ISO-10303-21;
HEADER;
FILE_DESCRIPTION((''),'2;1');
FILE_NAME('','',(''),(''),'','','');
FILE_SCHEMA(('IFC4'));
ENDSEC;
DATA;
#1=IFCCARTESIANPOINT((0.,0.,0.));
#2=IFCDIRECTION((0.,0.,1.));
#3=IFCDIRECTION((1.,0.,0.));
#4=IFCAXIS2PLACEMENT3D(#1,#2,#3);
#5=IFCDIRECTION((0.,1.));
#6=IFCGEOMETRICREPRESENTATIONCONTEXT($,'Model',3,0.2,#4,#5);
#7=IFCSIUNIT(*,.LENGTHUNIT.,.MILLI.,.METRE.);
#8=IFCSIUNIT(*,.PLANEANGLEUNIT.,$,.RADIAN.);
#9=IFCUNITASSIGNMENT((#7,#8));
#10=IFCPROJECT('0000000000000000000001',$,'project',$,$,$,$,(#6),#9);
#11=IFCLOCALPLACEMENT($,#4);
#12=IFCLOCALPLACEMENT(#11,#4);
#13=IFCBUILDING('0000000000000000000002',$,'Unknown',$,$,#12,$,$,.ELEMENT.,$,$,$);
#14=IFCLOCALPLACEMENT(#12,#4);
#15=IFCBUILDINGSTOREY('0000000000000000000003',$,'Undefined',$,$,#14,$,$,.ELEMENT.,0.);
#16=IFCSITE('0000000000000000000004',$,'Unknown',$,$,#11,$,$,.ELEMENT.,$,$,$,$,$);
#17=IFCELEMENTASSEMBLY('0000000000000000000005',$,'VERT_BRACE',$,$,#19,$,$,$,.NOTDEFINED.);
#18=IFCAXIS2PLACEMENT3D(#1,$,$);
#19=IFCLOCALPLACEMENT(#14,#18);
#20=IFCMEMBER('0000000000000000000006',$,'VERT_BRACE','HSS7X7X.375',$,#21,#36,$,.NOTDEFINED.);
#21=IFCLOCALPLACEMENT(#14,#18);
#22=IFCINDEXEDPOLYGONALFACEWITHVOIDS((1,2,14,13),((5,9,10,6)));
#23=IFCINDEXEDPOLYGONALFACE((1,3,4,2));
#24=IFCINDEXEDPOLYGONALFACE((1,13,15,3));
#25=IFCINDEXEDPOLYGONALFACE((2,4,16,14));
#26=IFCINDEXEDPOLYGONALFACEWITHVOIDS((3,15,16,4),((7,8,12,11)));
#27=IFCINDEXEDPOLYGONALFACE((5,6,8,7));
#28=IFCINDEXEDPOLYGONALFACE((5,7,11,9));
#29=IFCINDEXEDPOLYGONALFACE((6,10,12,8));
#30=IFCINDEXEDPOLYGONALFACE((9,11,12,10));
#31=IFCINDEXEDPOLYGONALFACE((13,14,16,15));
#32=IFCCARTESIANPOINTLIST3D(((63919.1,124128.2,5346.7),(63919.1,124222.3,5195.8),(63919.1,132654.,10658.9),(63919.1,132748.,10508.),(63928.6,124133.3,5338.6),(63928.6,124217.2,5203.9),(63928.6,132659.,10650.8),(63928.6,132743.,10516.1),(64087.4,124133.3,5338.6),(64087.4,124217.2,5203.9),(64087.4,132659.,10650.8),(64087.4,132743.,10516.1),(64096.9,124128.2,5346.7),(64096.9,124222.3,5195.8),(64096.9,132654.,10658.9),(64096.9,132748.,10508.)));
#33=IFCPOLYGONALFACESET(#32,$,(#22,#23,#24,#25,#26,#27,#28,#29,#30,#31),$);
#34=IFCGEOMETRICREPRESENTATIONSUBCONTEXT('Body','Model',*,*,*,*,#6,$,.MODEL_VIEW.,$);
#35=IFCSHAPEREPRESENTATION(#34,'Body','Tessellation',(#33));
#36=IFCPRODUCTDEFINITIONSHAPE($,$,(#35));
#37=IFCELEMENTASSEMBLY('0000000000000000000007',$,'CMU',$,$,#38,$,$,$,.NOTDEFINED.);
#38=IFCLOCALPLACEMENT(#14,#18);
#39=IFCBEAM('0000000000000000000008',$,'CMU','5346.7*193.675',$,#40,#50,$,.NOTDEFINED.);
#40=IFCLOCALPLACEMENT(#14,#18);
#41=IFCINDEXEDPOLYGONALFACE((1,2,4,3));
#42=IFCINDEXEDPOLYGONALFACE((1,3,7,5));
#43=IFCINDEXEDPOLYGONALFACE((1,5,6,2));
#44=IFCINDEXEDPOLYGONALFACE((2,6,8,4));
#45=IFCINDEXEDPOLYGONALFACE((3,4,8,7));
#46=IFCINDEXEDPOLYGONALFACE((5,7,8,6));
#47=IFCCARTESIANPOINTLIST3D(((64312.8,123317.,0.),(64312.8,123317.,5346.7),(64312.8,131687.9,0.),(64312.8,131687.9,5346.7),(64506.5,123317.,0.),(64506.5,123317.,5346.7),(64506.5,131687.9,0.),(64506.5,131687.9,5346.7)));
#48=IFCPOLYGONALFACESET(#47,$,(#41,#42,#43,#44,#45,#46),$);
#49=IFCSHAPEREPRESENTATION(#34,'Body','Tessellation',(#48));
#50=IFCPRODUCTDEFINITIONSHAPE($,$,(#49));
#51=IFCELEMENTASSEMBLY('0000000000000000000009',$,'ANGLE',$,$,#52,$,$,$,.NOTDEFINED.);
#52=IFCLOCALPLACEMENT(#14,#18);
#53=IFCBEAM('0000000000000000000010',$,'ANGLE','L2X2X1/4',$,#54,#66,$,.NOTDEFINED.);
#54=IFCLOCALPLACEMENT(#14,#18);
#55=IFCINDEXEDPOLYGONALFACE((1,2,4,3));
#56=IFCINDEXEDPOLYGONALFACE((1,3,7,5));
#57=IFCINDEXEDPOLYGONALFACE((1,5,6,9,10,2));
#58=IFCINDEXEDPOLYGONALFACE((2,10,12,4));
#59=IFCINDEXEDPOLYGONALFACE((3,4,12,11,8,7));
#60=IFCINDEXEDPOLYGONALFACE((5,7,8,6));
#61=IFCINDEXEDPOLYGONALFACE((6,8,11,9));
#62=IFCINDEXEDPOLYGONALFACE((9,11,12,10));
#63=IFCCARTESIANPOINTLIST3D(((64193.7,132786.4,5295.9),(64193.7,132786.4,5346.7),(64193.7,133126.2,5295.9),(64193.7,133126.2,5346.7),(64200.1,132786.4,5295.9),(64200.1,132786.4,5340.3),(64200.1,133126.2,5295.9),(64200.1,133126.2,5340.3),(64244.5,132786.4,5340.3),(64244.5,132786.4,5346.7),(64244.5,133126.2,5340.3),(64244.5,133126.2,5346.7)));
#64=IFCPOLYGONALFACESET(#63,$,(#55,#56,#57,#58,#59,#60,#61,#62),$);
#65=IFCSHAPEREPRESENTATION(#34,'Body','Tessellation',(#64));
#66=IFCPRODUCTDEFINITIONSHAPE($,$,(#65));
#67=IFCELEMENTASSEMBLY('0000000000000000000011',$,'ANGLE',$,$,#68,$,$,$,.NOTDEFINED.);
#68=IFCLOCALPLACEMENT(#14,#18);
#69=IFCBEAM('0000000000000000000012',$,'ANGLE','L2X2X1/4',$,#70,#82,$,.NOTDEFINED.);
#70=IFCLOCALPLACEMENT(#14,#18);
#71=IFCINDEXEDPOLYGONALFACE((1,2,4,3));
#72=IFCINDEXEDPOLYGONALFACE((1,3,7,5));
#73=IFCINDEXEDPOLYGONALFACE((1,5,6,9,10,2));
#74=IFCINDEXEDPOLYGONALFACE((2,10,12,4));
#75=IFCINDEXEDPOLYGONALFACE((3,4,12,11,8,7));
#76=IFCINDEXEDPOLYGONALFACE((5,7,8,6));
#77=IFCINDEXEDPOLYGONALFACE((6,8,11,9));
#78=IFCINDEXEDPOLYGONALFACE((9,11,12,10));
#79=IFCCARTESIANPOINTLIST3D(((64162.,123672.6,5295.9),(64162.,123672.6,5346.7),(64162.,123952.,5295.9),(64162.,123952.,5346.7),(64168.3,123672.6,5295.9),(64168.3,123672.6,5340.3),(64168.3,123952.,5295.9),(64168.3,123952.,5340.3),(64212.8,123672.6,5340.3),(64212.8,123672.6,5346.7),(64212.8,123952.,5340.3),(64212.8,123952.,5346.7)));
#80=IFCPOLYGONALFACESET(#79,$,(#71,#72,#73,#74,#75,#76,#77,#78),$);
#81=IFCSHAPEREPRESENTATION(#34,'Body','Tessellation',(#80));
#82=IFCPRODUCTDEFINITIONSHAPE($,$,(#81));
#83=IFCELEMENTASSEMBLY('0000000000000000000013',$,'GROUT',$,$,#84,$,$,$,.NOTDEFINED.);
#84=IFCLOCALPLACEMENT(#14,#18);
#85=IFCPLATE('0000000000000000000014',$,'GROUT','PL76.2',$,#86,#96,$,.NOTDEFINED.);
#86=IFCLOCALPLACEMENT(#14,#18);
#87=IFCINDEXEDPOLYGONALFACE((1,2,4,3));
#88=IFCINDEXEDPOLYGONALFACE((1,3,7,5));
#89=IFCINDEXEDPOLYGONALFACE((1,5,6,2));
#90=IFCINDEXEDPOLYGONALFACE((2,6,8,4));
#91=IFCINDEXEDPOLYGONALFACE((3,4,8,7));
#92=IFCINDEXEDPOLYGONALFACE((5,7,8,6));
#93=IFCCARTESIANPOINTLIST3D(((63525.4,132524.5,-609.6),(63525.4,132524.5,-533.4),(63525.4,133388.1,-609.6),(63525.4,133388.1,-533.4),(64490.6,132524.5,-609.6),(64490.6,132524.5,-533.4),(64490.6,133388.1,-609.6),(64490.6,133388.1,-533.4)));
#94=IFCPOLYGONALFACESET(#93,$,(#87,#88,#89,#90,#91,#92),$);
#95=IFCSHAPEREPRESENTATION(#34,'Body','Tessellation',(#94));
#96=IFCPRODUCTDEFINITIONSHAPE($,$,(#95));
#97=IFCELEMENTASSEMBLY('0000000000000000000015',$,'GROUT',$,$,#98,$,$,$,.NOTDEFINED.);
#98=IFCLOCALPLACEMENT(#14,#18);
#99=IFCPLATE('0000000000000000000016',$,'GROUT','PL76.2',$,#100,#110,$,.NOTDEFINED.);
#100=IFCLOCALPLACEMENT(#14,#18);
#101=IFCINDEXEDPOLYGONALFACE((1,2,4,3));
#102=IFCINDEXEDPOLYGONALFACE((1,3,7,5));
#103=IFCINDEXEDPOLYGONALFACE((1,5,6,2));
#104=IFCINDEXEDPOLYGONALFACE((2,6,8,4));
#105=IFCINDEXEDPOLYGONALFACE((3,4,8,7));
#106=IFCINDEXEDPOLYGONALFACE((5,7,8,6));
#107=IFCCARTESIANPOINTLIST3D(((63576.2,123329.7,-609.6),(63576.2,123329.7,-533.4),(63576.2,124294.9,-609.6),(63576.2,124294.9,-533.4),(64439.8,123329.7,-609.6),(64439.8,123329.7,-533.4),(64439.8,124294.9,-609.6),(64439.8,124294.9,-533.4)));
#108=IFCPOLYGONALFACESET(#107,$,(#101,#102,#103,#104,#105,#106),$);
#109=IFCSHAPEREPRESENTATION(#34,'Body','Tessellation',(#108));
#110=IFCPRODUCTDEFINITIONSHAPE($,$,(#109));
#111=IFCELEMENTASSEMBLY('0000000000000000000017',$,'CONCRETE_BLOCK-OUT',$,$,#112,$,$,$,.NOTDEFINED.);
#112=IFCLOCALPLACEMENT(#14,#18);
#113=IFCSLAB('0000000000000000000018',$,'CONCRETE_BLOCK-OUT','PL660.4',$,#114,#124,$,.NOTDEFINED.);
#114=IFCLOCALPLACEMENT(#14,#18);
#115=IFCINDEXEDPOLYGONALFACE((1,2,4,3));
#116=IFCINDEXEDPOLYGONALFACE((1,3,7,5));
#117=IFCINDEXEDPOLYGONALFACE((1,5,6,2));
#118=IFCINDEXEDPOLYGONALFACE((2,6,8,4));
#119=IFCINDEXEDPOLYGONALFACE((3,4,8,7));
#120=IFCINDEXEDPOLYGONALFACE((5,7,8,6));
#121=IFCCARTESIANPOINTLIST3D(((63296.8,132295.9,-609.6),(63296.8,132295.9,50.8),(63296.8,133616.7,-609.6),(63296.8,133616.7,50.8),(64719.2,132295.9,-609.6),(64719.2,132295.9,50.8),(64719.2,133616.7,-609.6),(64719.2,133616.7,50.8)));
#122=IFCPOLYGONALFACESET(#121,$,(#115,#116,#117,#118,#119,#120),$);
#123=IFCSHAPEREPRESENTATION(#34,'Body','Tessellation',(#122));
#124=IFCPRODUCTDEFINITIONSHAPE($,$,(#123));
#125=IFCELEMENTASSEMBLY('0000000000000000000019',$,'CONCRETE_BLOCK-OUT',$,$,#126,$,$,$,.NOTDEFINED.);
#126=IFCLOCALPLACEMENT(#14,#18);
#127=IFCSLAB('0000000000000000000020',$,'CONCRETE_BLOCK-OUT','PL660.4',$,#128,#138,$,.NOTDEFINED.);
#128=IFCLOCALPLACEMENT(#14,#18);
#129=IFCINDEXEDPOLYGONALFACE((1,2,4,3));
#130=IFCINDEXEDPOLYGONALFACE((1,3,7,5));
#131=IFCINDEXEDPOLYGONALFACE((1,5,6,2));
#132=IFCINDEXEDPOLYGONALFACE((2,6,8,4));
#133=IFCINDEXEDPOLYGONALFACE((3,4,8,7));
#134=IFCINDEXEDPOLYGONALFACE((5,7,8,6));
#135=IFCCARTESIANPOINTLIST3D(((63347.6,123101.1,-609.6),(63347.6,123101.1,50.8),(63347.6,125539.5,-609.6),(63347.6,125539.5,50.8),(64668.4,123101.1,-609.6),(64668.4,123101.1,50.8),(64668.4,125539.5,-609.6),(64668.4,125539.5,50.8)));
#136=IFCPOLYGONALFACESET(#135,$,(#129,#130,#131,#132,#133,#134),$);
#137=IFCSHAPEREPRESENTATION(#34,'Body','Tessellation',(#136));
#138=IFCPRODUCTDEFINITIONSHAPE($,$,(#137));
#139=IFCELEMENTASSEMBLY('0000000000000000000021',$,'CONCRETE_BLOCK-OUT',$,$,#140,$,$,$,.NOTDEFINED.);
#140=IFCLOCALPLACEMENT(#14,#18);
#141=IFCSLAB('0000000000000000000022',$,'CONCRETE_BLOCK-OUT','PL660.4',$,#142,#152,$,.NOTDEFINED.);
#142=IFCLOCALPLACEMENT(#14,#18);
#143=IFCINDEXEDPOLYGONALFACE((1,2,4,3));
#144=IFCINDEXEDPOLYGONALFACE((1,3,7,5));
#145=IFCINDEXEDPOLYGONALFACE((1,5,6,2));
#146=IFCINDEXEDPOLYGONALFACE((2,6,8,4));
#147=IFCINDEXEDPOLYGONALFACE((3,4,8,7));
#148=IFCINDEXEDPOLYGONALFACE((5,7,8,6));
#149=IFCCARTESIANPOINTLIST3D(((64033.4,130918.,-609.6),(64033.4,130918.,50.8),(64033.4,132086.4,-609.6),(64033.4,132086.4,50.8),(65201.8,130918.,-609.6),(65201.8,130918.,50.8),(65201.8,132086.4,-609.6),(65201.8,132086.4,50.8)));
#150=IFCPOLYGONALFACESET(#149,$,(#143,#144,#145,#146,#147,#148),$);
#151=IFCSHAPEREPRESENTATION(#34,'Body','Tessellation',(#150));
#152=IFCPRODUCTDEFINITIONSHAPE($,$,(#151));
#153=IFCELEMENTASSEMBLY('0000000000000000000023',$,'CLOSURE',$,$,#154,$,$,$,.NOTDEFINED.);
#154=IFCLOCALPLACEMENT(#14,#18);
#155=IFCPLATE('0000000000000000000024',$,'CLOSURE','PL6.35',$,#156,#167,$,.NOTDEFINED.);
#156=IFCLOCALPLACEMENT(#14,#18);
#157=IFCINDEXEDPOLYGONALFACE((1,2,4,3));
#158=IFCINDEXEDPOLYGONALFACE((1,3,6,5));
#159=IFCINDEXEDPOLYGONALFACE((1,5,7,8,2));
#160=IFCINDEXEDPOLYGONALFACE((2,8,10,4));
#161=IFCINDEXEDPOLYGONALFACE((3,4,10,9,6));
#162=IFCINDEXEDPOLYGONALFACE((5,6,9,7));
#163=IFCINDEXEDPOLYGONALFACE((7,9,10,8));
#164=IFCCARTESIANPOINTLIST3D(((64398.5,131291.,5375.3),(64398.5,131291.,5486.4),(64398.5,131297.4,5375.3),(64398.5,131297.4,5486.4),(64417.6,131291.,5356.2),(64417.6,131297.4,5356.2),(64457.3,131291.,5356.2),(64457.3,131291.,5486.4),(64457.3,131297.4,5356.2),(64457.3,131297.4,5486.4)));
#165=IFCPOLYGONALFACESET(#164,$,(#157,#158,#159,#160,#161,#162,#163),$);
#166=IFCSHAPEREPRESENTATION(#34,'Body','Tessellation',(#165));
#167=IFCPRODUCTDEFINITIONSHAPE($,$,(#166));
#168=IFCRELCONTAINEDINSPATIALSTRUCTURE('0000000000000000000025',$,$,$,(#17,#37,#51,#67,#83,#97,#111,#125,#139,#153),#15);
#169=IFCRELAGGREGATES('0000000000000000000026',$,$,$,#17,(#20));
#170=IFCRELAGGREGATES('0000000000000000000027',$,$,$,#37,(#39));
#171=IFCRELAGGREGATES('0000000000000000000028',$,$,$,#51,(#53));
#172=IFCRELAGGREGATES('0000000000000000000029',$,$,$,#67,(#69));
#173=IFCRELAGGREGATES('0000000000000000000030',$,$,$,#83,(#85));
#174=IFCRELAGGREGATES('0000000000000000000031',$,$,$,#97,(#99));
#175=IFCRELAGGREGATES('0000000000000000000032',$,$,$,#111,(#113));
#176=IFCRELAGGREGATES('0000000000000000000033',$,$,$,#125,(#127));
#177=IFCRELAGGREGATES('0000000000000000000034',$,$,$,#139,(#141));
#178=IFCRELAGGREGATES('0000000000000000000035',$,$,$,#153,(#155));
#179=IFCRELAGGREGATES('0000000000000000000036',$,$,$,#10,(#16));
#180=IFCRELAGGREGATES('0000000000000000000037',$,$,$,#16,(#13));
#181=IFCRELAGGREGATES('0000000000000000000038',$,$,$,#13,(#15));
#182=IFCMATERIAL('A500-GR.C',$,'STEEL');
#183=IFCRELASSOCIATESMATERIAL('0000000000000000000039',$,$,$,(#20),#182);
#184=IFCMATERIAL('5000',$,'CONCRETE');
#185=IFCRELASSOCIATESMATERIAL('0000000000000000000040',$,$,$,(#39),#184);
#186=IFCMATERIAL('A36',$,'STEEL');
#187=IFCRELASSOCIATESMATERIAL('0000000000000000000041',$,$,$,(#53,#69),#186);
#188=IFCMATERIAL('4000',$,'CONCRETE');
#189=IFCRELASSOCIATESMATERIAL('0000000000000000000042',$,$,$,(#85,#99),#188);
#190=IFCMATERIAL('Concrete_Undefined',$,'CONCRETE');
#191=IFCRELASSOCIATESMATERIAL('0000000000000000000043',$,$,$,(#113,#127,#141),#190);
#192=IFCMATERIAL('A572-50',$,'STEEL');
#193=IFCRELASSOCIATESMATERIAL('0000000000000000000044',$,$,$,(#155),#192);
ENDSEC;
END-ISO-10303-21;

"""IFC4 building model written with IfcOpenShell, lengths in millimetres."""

from ifc_helpers import new_model, si_unit, direction, frame, origin_with_axes, place, context, subcontext, project, spatial, line, indexed_curve, outline, extrude, material, element, aggregate, save


model = new_model("IFC4")

# Units and contexts
model_context = context("Model", 3, precision=0.2, world=origin_with_axes(), true_north=direction((0.0, 1.0)))
body_context = subcontext(model_context, "Body", "Model", "MODEL_VIEW")
ifc_project = project(units=[si_unit("LENGTHUNIT", "METRE", prefix="MILLI"), si_unit("PLANEANGLEUNIT", "RADIAN")], contexts=[model_context])

# Site, building, storey
site_placement = place(None, origin_with_axes())
site = spatial("IfcSite", under=ifc_project, at=site_placement, Name="Unknown", CompositionType="ELEMENT")
building_placement = place(site_placement, origin_with_axes())
building = spatial("IfcBuilding", under=site, at=building_placement, Name="Unknown", CompositionType="ELEMENT")
storey_placement = place(building_placement, origin_with_axes())
storey = spatial("IfcBuildingStorey", under=building, at=storey_placement, Name="Undefined", CompositionType="ELEMENT", Elevation=0.0)

# Shared definitions
ifc_material_1 = material(Name="4000", Category="CONCRETE")

# Shared definitions
ifc_material_2 = material(Name="A572-50", Category="STEEL")

# Element assembly, member
ifc_material_3 = material(Name="A500-GR.C", Category="STEEL")
assembly_1_placement = place(storey_placement, frame((64008.0, 124175.2, 5271.2), z_axis=(1.0, 0.0, 0.0), x_axis=(0.0, 0.848728, 0.528829)))
assembly_1 = element("IfcElementAssembly", 1, at=assembly_1_placement, inside=storey, Name="VERT_BRACE", PredefinedType="NOTDEFINED")
member_1_placement = place(assembly_1_placement, origin_with_axes())
member_1 = element("IfcMember", 2, at=member_1_placement, material=ifc_material_3, Name="VERT_BRACE", Description="HSS7X7X.375", PredefinedType="NOTDEFINED", context=body_context, shape_type="SolidModel", body=[
    extrude(outline(indexed_curve([(-88.9, -88.9), (88.9, -88.9), (88.9, 88.9), (-88.9, 88.9)], segments=[line(1, 2, 3, 4, 1)]), holes=[indexed_curve([(-79.4, -79.4), (-79.4, 79.4), (79.4, 79.4), (79.4, -79.4)], segments=[line(1, 2, 3, 4, 1)])]), frame((0.0, 0.0, 0.0), z_axis=(-1.0, 0.0, 0.0), x_axis=(0.0, 0.0, 1.0)), (0.0, 0.0, -1.0), 10045.3),
])
aggregate(assembly_1, [member_1])

# Element assemblies, beams
assembly_2_placement = place(storey_placement, frame((64409.6, 131687.9, 2673.3), z_axis=(-1.0, 0.0, 0.0), x_axis=(0.0, -1.0, 0.0)))
assembly_2 = element("IfcElementAssembly", 3, at=assembly_2_placement, inside=storey, Name="CMU", PredefinedType="NOTDEFINED")
ifc_material_4 = material(Name="5000", Category="CONCRETE")
beam_1_placement = place(assembly_2_placement, origin_with_axes())
beam_1 = element("IfcBeam", 4, at=beam_1_placement, material=ifc_material_4, Name="CMU", Description="5346.7*193.675", PredefinedType="NOTDEFINED", context=body_context, shape_type="SolidModel", body=[
    extrude(outline(indexed_curve([(-96.8, -2673.3), (96.8, -2673.3), (96.8, 2673.3), (-96.8, 2673.3)], segments=[line(1, 2, 3, 4, 1)])), frame((0.0, 0.0, 0.0), z_axis=(-1.0, 0.0, 0.0), x_axis=(0.0, 0.0, 1.0)), (0.0, 0.0, -1.0), 8370.9),
])
aggregate(assembly_2, [beam_1])
assembly_3_placement = place(storey_placement, frame((64219.1, 132786.4, 5321.3), z_axis=(0.0, 0.0, -1.0), x_axis=(0.0, 1.0, 0.0)))
assembly_3 = element("IfcElementAssembly", 5, at=assembly_3_placement, inside=storey, Name="ANGLE", PredefinedType="NOTDEFINED")
ifc_material_5 = material(Name="A36", Category="STEEL")
beam_2_placement = place(assembly_3_placement, origin_with_axes())
beam_2 = element("IfcBeam", 6, at=beam_2_placement, material=ifc_material_5, Name="ANGLE", Description="L2X2X1/4", PredefinedType="NOTDEFINED", context=body_context, shape_type="SolidModel", body=[
    extrude(outline(indexed_curve([(-25.4, -25.4), (25.4, -25.4), (25.4, -19.1), (-19.1, -19.1), (-19.1, 25.4), (-25.4, 25.4)], segments=[line(1, 2, 3, 4, 5, 6, 1)])), frame((0.0, 0.0, 0.0), z_axis=(-1.0, 0.0, 0.0), x_axis=(0.0, 0.0, 1.0)), (0.0, 0.0, -1.0), 339.7),
])
aggregate(assembly_3, [beam_2])
assembly_4_placement = place(storey_placement, frame((64187.4, 123672.6, 5321.3), z_axis=(0.0, 0.0, -1.0), x_axis=(0.0, 1.0, 0.0)))
assembly_4 = element("IfcElementAssembly", 7, at=assembly_4_placement, inside=storey, Name="ANGLE", PredefinedType="NOTDEFINED")
beam_3_placement = place(assembly_4_placement, origin_with_axes())
beam_3 = element("IfcBeam", 8, at=beam_3_placement, material=ifc_material_5, Name="ANGLE", Description="L2X2X1/4", PredefinedType="NOTDEFINED", context=body_context, shape_type="SolidModel", body=[
    extrude(outline(indexed_curve([(-25.4, -25.4), (25.4, -25.4), (25.4, -19.1), (-19.1, -19.1), (-19.1, 25.4), (-25.4, 25.4)], segments=[line(1, 2, 3, 4, 5, 6, 1)])), frame((0.0, 0.0, 0.0), z_axis=(-1.0, 0.0, 0.0), x_axis=(0.0, 0.0, 1.0)), (0.0, 0.0, -1.0), 279.4),
])
aggregate(assembly_4, [beam_3])

# Element assemblies, plates
assembly_5_placement = place(storey_placement, frame((64490.6, 132524.5, -571.5), z_axis=(0.0, 0.0, 1.0), x_axis=(0.0, 1.0, 0.0)))
assembly_5 = element("IfcElementAssembly", 9, at=assembly_5_placement, inside=storey, Name="GROUT", PredefinedType="NOTDEFINED")
plate_1_placement = place(assembly_5_placement, origin_with_axes())
plate_1 = element("IfcPlate", 10, at=plate_1_placement, material=ifc_material_1, Name="GROUT", Description="PL76.2", PredefinedType="NOTDEFINED", context=body_context, shape_type="SolidModel", body=[
    extrude(outline(indexed_curve([(0.0, 0.0), (863.6, 0.0), (863.6, 965.2), (0.0, 965.2)], segments=[line(1, 2, 3, 4, 1)])), frame((0.0, 0.0, 38.1), z_axis=(0.0, 0.0, 1.0), x_axis=(1.0, 0.0, 0.0)), (0.0, 0.0, -1.0), 76.2),
])
aggregate(assembly_5, [plate_1])
assembly_6_placement = place(storey_placement, frame((64439.8, 124294.9, -571.5), z_axis=(0.0, 0.0, 1.0), x_axis=(-1.0, 0.0, 0.0)))
assembly_6 = element("IfcElementAssembly", 11, at=assembly_6_placement, inside=storey, Name="GROUT", PredefinedType="NOTDEFINED")
plate_2_placement = place(assembly_6_placement, origin_with_axes())
plate_2 = element("IfcPlate", 12, at=plate_2_placement, material=ifc_material_1, Name="GROUT", Description="PL76.2", PredefinedType="NOTDEFINED", context=body_context, shape_type="SolidModel", body=[
    extrude(outline(indexed_curve([(0.0, 0.0), (863.6, 0.0), (863.6, 965.2), (0.0, 965.2)], segments=[line(1, 2, 3, 4, 1)])), frame((0.0, 0.0, 38.1), z_axis=(0.0, 0.0, 1.0), x_axis=(1.0, 0.0, 0.0)), (0.0, 0.0, -1.0), 76.2),
])
aggregate(assembly_6, [plate_2])

# Element assemblies, slabs
assembly_7_placement = place(storey_placement, frame((64719.2, 133616.7, -279.4), z_axis=(0.0, 0.0, 1.0), x_axis=(-1.0, 0.0, 0.0)))
assembly_7 = element("IfcElementAssembly", 13, at=assembly_7_placement, inside=storey, Name="CONCRETE_BLOCK-OUT", PredefinedType="NOTDEFINED")
ifc_material_6 = material(Name="Concrete_Undefined", Category="CONCRETE")
slab_1_placement = place(assembly_7_placement, origin_with_axes())
slab_1 = element("IfcSlab", 14, at=slab_1_placement, material=ifc_material_6, Name="CONCRETE_BLOCK-OUT", Description="PL660.4", PredefinedType="NOTDEFINED", context=body_context, shape_type="SolidModel", body=[
    extrude(outline(indexed_curve([(0.0, 0.0), (1422.4, 0.0), (1422.4, 1320.8), (0.0, 1320.8)], segments=[line(1, 2, 3, 4, 1)])), frame((0.0, 0.0, 330.2), z_axis=(0.0, 0.0, 1.0), x_axis=(1.0, 0.0, 0.0)), (0.0, 0.0, -1.0), 660.4),
])
aggregate(assembly_7, [slab_1])
assembly_8_placement = place(storey_placement, frame((64668.4, 125539.5, -279.4), z_axis=(0.0, 0.0, 1.0), x_axis=(-1.0, 0.0, 0.0)))
assembly_8 = element("IfcElementAssembly", 15, at=assembly_8_placement, inside=storey, Name="CONCRETE_BLOCK-OUT", PredefinedType="NOTDEFINED")
slab_2_placement = place(assembly_8_placement, origin_with_axes())
slab_2 = element("IfcSlab", 16, at=slab_2_placement, material=ifc_material_6, Name="CONCRETE_BLOCK-OUT", Description="PL660.4", PredefinedType="NOTDEFINED", context=body_context, shape_type="SolidModel", body=[
    extrude(outline(indexed_curve([(0.0, 0.0), (1320.8, 0.0), (1320.8, 2438.4), (0.0, 2438.4)], segments=[line(1, 2, 3, 4, 1)])), frame((0.0, 0.0, 330.2), z_axis=(0.0, 0.0, 1.0), x_axis=(1.0, 0.0, 0.0)), (0.0, 0.0, -1.0), 660.4),
])
aggregate(assembly_8, [slab_2])
assembly_9_placement = place(storey_placement, frame((65201.8, 132086.4, -279.4), z_axis=(0.0, 0.0, 1.0), x_axis=(-1.0, 0.0, 0.0)))
assembly_9 = element("IfcElementAssembly", 17, at=assembly_9_placement, inside=storey, Name="CONCRETE_BLOCK-OUT", PredefinedType="NOTDEFINED")
slab_3_placement = place(assembly_9_placement, origin_with_axes())
slab_3 = element("IfcSlab", 18, at=slab_3_placement, material=ifc_material_6, Name="CONCRETE_BLOCK-OUT", Description="PL660.4", PredefinedType="NOTDEFINED", context=body_context, shape_type="SolidModel", body=[
    extrude(outline(indexed_curve([(0.0, 0.0), (1168.4, 0.0), (1168.4, 1168.4), (0.0, 1168.4)], segments=[line(1, 2, 3, 4, 1)])), frame((0.0, 0.0, 330.2), z_axis=(0.0, 0.0, 1.0), x_axis=(1.0, 0.0, 0.0)), (0.0, 0.0, -1.0), 660.4),
])
aggregate(assembly_9, [slab_3])

# Element assembly, plate
assembly_10_placement = place(storey_placement, frame((64457.3, 131294.2, 5356.2), z_axis=(0.0, 1.0, 0.0), x_axis=(-1.0, 0.0, 0.0)))
assembly_10 = element("IfcElementAssembly", 19, at=assembly_10_placement, inside=storey, Name="CLOSURE", PredefinedType="NOTDEFINED")
plate_3_placement = place(assembly_10_placement, origin_with_axes())
plate_3 = element("IfcPlate", 20, at=plate_3_placement, material=ifc_material_2, Name="CLOSURE", Description="PL6.35", PredefinedType="NOTDEFINED", context=body_context, shape_type="SolidModel", body=[
    extrude(outline(indexed_curve([(0.0, 0.0), (39.7, 0.0), (58.7, 19.1), (58.7, 130.2), (0.0, 130.2)], segments=[line(1, 2, 3, 4, 5, 1)])), frame((0.0, 0.0, 3.2), z_axis=(0.0, 0.0, 1.0), x_axis=(1.0, 0.0, 0.0)), (0.0, 0.0, -1.0), 6.3),
])
aggregate(assembly_10, [plate_3])

save(model, "model.ifc")
